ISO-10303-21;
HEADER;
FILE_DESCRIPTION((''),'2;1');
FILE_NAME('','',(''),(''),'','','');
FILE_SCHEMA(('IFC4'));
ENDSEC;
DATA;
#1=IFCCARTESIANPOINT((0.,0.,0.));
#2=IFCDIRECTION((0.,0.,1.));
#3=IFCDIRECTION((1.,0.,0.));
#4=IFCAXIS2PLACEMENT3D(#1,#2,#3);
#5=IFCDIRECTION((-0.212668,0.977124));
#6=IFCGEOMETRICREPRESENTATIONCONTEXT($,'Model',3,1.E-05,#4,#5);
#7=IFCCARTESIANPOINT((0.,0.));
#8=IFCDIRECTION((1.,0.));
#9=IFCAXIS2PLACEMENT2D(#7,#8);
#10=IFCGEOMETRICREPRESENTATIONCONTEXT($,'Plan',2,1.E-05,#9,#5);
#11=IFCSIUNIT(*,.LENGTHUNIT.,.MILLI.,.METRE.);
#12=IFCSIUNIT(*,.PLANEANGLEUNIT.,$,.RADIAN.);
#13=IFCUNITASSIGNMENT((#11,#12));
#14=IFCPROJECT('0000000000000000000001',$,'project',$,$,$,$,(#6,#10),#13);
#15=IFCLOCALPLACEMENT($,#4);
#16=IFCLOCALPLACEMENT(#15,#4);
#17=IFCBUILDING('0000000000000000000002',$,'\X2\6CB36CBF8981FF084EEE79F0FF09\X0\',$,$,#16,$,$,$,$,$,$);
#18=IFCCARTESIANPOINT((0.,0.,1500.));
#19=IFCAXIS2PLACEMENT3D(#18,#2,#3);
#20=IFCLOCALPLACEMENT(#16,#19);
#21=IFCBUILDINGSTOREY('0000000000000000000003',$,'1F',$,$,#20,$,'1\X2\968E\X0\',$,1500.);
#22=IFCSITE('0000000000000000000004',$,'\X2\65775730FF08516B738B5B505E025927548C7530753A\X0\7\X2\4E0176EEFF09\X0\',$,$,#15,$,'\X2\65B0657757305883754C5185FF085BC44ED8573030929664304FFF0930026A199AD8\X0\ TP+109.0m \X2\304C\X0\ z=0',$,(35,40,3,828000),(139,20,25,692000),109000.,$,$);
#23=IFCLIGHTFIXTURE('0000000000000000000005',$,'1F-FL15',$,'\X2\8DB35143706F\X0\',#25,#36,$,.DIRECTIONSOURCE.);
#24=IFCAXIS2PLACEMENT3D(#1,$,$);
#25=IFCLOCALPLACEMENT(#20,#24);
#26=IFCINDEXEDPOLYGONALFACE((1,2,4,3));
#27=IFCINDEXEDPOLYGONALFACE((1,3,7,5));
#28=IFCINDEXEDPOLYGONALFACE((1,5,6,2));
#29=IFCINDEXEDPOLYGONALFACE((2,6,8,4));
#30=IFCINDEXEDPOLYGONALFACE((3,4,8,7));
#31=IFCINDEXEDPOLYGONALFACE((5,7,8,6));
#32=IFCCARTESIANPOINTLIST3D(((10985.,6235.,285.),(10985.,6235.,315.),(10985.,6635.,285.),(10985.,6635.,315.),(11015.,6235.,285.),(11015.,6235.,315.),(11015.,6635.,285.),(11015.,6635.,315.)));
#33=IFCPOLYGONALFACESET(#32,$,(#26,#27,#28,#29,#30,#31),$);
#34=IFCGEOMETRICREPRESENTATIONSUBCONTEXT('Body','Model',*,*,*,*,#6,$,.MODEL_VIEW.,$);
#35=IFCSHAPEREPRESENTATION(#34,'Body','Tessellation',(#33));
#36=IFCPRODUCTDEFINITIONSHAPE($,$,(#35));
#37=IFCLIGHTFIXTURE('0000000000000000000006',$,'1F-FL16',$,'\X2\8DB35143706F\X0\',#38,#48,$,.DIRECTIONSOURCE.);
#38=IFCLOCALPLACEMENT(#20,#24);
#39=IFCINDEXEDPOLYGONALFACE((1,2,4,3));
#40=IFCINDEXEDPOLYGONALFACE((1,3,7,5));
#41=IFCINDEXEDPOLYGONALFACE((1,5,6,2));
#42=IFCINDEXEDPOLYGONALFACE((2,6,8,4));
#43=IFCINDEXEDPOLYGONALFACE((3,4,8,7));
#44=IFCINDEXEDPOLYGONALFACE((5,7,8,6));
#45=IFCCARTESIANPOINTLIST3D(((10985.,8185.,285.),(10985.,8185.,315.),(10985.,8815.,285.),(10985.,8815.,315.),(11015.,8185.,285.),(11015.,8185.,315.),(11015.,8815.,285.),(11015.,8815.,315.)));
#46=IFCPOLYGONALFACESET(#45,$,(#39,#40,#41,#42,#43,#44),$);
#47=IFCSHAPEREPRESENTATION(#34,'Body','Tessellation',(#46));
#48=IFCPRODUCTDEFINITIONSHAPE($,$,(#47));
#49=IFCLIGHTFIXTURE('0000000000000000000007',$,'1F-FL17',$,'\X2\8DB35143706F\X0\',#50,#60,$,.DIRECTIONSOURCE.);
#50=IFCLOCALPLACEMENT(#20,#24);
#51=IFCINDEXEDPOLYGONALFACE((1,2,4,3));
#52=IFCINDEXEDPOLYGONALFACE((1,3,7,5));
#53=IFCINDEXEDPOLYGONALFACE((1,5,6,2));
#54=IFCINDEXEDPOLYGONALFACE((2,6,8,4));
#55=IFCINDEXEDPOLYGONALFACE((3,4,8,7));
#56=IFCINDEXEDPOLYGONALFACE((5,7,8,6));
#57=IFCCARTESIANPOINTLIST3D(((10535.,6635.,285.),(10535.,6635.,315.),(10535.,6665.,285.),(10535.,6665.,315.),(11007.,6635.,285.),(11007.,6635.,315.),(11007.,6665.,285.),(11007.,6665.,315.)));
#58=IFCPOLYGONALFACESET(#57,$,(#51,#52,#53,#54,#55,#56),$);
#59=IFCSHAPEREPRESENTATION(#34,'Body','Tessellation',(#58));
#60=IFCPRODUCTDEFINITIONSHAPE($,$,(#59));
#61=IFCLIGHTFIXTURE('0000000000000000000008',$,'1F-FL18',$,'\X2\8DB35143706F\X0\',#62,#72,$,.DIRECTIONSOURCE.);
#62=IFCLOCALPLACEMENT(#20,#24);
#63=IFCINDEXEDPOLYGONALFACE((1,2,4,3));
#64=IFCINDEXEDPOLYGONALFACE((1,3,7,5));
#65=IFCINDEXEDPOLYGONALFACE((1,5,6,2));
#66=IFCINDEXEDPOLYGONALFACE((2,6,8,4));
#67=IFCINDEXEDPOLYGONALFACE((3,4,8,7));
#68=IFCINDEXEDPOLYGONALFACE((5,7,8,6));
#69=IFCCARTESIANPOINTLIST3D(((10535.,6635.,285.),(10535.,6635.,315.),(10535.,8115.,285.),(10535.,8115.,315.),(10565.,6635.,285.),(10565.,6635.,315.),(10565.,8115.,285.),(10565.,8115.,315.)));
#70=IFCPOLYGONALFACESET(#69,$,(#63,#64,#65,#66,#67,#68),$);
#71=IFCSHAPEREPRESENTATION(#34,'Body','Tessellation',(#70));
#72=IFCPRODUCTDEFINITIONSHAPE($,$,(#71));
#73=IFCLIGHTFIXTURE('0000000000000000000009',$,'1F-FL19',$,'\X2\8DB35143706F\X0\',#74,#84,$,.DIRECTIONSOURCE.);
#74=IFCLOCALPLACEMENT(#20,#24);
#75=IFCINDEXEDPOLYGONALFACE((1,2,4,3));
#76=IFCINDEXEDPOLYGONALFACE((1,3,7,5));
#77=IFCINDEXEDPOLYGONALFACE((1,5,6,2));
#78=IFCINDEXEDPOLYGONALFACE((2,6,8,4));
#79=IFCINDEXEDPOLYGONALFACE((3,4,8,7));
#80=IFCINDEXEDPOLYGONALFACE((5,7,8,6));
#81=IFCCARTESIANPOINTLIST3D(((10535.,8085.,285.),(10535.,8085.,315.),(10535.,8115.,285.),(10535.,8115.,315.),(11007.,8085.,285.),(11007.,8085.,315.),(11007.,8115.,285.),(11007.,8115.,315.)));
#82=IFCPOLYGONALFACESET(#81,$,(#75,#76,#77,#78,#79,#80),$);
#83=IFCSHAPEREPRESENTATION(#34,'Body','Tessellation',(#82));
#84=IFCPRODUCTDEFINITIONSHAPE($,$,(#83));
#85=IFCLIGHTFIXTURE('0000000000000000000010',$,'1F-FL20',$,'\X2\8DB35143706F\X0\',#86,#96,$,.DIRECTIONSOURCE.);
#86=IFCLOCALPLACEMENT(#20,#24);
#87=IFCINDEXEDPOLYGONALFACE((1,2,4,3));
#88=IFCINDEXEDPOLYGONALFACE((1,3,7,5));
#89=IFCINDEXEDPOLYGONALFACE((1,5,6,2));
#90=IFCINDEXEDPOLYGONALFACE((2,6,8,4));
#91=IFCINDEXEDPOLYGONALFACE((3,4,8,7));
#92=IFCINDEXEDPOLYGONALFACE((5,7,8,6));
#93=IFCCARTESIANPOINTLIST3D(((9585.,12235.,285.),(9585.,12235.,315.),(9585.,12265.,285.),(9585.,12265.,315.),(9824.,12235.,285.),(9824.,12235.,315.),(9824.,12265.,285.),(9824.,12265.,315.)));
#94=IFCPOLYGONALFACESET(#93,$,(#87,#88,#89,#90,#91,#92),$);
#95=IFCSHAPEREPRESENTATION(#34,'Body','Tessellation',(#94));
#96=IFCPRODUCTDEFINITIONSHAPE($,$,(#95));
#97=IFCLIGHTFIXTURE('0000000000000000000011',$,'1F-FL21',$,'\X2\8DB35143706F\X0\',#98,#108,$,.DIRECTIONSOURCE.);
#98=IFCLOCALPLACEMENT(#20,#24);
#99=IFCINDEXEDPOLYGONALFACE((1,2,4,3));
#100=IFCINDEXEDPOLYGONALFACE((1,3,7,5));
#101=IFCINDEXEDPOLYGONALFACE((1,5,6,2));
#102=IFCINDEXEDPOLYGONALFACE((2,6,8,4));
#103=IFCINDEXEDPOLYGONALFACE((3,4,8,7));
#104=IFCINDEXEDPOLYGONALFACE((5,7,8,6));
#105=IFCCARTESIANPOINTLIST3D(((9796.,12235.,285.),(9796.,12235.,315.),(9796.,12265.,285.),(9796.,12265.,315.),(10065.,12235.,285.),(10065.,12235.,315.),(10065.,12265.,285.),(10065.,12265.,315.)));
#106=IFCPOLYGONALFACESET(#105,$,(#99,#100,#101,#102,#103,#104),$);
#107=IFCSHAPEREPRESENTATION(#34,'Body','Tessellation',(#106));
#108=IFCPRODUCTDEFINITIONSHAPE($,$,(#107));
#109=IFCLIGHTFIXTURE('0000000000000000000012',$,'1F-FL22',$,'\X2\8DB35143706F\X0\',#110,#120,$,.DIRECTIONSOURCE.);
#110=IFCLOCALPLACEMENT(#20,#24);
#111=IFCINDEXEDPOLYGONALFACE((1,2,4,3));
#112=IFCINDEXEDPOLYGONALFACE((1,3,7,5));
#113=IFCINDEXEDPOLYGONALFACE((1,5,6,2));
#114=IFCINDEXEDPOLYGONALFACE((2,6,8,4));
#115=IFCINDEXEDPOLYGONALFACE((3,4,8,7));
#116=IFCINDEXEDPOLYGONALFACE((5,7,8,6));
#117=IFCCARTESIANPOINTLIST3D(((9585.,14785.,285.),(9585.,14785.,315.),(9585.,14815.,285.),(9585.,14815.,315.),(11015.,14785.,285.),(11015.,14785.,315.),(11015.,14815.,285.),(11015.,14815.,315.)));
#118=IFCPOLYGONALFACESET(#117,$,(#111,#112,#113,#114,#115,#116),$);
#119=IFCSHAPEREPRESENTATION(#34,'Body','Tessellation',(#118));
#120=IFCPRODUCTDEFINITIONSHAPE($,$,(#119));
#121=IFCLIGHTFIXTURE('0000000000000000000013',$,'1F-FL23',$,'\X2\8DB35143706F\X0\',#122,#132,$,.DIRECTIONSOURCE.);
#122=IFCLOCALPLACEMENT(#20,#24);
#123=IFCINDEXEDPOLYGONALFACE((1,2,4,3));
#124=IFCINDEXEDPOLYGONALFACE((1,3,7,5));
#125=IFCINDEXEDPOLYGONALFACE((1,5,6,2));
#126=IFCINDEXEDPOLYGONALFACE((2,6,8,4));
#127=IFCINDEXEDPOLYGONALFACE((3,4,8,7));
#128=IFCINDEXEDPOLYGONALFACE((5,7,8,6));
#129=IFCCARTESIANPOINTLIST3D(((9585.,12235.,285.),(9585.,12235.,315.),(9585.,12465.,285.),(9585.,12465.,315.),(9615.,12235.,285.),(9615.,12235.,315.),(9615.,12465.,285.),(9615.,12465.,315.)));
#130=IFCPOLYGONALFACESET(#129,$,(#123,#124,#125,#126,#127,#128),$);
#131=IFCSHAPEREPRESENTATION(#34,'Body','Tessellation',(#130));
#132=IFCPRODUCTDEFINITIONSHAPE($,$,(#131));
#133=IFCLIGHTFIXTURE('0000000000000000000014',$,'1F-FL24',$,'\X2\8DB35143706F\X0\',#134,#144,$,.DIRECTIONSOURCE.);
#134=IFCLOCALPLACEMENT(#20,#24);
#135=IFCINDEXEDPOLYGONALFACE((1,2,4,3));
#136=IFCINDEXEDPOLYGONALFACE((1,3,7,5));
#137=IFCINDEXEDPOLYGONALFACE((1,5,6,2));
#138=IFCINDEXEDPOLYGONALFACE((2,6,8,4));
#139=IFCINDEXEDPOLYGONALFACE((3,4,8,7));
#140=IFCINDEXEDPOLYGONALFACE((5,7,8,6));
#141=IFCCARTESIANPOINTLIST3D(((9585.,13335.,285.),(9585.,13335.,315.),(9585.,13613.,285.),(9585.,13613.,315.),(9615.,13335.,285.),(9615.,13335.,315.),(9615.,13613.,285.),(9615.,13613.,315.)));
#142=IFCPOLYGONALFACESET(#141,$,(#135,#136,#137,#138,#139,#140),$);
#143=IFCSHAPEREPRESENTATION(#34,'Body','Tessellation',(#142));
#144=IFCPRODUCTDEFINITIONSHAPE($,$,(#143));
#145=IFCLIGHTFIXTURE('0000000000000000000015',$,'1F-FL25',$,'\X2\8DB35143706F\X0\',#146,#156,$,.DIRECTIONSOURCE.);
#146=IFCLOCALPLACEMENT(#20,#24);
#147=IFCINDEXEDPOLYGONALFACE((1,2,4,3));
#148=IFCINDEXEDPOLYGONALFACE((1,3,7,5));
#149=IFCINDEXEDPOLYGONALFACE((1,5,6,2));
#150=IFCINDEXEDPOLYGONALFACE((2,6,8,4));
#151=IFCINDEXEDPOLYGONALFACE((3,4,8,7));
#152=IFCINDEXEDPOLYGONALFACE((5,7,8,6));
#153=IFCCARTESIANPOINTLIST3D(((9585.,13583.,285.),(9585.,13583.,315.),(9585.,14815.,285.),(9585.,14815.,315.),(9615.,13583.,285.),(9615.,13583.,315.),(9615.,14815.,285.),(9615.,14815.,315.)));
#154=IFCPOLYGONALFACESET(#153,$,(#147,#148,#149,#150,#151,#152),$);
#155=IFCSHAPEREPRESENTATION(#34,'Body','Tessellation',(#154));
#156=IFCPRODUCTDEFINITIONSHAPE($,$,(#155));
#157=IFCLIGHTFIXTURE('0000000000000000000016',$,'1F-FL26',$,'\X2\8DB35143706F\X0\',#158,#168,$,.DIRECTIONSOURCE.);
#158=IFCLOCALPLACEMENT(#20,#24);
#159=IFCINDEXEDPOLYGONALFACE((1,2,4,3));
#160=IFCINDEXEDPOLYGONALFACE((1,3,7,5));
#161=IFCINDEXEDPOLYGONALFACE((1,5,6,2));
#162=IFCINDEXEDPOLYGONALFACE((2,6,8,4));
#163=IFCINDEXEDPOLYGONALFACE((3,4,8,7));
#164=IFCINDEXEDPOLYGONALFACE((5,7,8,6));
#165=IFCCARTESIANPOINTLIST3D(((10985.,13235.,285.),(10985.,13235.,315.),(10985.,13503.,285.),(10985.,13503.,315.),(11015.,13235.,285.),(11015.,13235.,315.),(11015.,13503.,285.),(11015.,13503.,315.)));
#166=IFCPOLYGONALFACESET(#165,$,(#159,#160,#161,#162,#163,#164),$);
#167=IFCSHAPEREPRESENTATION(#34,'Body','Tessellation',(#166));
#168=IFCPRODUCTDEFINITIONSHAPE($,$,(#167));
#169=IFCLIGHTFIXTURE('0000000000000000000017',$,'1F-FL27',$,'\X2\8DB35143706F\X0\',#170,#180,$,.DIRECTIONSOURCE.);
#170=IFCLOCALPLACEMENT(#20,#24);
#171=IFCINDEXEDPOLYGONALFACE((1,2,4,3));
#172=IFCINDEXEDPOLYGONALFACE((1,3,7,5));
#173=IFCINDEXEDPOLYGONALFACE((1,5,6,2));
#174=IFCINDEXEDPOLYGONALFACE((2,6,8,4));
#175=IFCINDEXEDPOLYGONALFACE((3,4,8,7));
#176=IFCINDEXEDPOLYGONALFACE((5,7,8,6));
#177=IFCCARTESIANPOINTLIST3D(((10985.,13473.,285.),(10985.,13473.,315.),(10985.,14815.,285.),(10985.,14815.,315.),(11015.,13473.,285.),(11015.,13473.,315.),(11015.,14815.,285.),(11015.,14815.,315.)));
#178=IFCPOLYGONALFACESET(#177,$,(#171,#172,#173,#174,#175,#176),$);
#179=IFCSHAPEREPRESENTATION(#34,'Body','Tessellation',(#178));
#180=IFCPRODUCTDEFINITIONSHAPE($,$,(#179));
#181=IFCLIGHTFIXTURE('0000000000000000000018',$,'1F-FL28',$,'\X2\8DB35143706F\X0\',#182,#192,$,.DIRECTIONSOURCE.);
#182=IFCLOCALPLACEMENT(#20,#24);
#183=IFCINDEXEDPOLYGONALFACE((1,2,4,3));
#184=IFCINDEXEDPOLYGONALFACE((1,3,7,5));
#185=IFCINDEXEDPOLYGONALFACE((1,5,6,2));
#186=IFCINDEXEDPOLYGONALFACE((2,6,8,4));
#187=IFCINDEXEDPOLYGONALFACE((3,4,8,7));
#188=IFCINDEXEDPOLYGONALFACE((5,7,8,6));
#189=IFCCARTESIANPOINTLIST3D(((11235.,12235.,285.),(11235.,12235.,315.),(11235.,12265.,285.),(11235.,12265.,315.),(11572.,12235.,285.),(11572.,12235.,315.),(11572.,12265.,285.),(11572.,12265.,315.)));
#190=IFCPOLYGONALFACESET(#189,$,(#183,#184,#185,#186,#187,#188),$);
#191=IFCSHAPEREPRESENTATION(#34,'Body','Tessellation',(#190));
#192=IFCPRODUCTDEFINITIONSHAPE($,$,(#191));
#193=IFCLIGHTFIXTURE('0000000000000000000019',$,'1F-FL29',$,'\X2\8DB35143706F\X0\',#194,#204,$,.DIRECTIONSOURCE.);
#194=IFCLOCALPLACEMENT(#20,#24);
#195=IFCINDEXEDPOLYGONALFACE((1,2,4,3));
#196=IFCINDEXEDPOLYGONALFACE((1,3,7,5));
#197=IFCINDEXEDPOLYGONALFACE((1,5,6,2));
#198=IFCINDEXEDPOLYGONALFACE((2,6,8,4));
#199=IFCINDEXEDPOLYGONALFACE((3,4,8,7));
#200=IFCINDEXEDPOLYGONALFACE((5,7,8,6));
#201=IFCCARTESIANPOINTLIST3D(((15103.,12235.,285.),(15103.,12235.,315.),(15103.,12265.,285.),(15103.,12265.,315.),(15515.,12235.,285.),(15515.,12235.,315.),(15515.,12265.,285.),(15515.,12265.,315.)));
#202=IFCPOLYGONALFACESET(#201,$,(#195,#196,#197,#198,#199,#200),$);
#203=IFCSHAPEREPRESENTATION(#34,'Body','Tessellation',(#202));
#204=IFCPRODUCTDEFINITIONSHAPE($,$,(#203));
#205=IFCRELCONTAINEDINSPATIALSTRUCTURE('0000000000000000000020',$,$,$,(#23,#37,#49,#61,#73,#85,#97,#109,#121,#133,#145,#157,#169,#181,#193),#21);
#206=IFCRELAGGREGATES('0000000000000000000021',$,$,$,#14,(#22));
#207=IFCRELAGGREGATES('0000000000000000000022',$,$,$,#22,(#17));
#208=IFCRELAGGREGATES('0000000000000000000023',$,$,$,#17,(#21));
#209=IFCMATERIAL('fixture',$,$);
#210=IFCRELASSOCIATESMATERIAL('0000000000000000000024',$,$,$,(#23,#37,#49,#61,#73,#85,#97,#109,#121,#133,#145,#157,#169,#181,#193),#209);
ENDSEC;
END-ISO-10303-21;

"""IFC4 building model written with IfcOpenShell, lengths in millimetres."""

from ifc_helpers import new_model, si_unit, direction, frame, frame_2d, origin_with_axes, origin_2d_with_axis, place, context, subcontext, project, spatial, rectangle, extrude, material, element, save


model = new_model("IFC4")

# Units and contexts
model_context = context("Model", 3, precision=1e-05, world=origin_with_axes(), true_north=direction((-0.212668, 0.977124)))
plan_context = context("Plan", 2, precision=1e-05, world=origin_2d_with_axis(), true_north=direction((-0.212668, 0.977124)))
body_context = subcontext(model_context, "Body", "Model", "MODEL_VIEW")
ifc_project = project(units=[si_unit("LENGTHUNIT", "METRE", prefix="MILLI"), si_unit("PLANEANGLEUNIT", "RADIAN")], contexts=[model_context, plan_context])

# Site, building, storey
site_placement = place(None, origin_with_axes())
site = spatial("IfcSite", under=ifc_project, at=site_placement, Name="敷地（八王子市大和田町7丁目）", LongName="新敷地境界内（寄付地を除く）。標高 TP+109.0m が z=0", RefLatitude=(35, 40, 3, 828000), RefLongitude=(139, 20, 25, 692000), RefElevation=109000.0)
building_placement = place(site_placement, origin_with_axes())
building = spatial("IfcBuilding", under=site, at=building_placement, Name="河沿要（仮称）")
storey_placement = place(building_placement, frame((0.0, 0.0, 1500.0), z_axis=(0.0, 0.0, 1.0), x_axis=(1.0, 0.0, 0.0)))
storey = spatial("IfcBuildingStorey", under=building, at=storey_placement, Name="1F", LongName="1階", Elevation=1500.0)

# Light fixtures
ifc_material = material(Name="fixture")
light_fixture_1_placement = place(storey_placement, origin_with_axes())
element("IfcLightFixture", 1, at=light_fixture_1_placement, inside=storey, material=ifc_material, Name="1F-FL15", ObjectType="足元灯", PredefinedType="DIRECTIONSOURCE", context=body_context, shape_type="SweptSolid", body=[
    extrude(rectangle(XDim=30.0, YDim=400.0, at=frame_2d((11000.0, 6435.0))), frame((0.0, 0.0, 285.0)), (0.0, 0.0, 1.0), 30.0),
])
light_fixture_2_placement = place(storey_placement, origin_with_axes())
element("IfcLightFixture", 2, at=light_fixture_2_placement, inside=storey, material=ifc_material, Name="1F-FL16", ObjectType="足元灯", PredefinedType="DIRECTIONSOURCE", context=body_context, shape_type="SweptSolid", body=[
    extrude(rectangle(XDim=30.0, YDim=630.0, at=frame_2d((11000.0, 8500.0))), frame((0.0, 0.0, 285.0)), (0.0, 0.0, 1.0), 30.0),
])
light_fixture_3_placement = place(storey_placement, origin_with_axes())
element("IfcLightFixture", 3, at=light_fixture_3_placement, inside=storey, material=ifc_material, Name="1F-FL17", ObjectType="足元灯", PredefinedType="DIRECTIONSOURCE", context=body_context, shape_type="SweptSolid", body=[
    extrude(rectangle(XDim=472.0, YDim=30.0, at=frame_2d((10771.0, 6650.0))), frame((0.0, 0.0, 285.0)), (0.0, 0.0, 1.0), 30.0),
])
light_fixture_4_placement = place(storey_placement, origin_with_axes())
element("IfcLightFixture", 4, at=light_fixture_4_placement, inside=storey, material=ifc_material, Name="1F-FL18", ObjectType="足元灯", PredefinedType="DIRECTIONSOURCE", context=body_context, shape_type="SweptSolid", body=[
    extrude(rectangle(XDim=30.0, YDim=1480.0, at=frame_2d((10550.0, 7375.0))), frame((0.0, 0.0, 285.0)), (0.0, 0.0, 1.0), 30.0),
])
light_fixture_5_placement = place(storey_placement, origin_with_axes())
element("IfcLightFixture", 5, at=light_fixture_5_placement, inside=storey, material=ifc_material, Name="1F-FL19", ObjectType="足元灯", PredefinedType="DIRECTIONSOURCE", context=body_context, shape_type="SweptSolid", body=[
    extrude(rectangle(XDim=472.0, YDim=30.0, at=frame_2d((10771.0, 8100.0))), frame((0.0, 0.0, 285.0)), (0.0, 0.0, 1.0), 30.0),
])
light_fixture_6_placement = place(storey_placement, origin_with_axes())
element("IfcLightFixture", 6, at=light_fixture_6_placement, inside=storey, material=ifc_material, Name="1F-FL20", ObjectType="足元灯", PredefinedType="DIRECTIONSOURCE", context=body_context, shape_type="SweptSolid", body=[
    extrude(rectangle(XDim=239.0, YDim=30.0, at=frame_2d((9704.5, 12250.0))), frame((0.0, 0.0, 285.0)), (0.0, 0.0, 1.0), 30.0),
])
light_fixture_7_placement = place(storey_placement, origin_with_axes())
element("IfcLightFixture", 7, at=light_fixture_7_placement, inside=storey, material=ifc_material, Name="1F-FL21", ObjectType="足元灯", PredefinedType="DIRECTIONSOURCE", context=body_context, shape_type="SweptSolid", body=[
    extrude(rectangle(XDim=269.0, YDim=30.0, at=frame_2d((9930.5, 12250.0))), frame((0.0, 0.0, 285.0)), (0.0, 0.0, 1.0), 30.0),
])
light_fixture_8_placement = place(storey_placement, origin_with_axes())
element("IfcLightFixture", 8, at=light_fixture_8_placement, inside=storey, material=ifc_material, Name="1F-FL22", ObjectType="足元灯", PredefinedType="DIRECTIONSOURCE", context=body_context, shape_type="SweptSolid", body=[
    extrude(rectangle(XDim=1430.0, YDim=30.0, at=frame_2d((10300.0, 14800.0))), frame((0.0, 0.0, 285.0)), (0.0, 0.0, 1.0), 30.0),
])
light_fixture_9_placement = place(storey_placement, origin_with_axes())
element("IfcLightFixture", 9, at=light_fixture_9_placement, inside=storey, material=ifc_material, Name="1F-FL23", ObjectType="足元灯", PredefinedType="DIRECTIONSOURCE", context=body_context, shape_type="SweptSolid", body=[
    extrude(rectangle(XDim=30.0, YDim=230.0, at=frame_2d((9600.0, 12350.0))), frame((0.0, 0.0, 285.0)), (0.0, 0.0, 1.0), 30.0),
])
light_fixture_10_placement = place(storey_placement, origin_with_axes())
element("IfcLightFixture", 10, at=light_fixture_10_placement, inside=storey, material=ifc_material, Name="1F-FL24", ObjectType="足元灯", PredefinedType="DIRECTIONSOURCE", context=body_context, shape_type="SweptSolid", body=[
    extrude(rectangle(XDim=30.0, YDim=278.0, at=frame_2d((9600.0, 13474.0))), frame((0.0, 0.0, 285.0)), (0.0, 0.0, 1.0), 30.0),
])
light_fixture_11_placement = place(storey_placement, origin_with_axes())
element("IfcLightFixture", 11, at=light_fixture_11_placement, inside=storey, material=ifc_material, Name="1F-FL25", ObjectType="足元灯", PredefinedType="DIRECTIONSOURCE", context=body_context, shape_type="SweptSolid", body=[
    extrude(rectangle(XDim=30.0, YDim=1232.0, at=frame_2d((9600.0, 14199.0))), frame((0.0, 0.0, 285.0)), (0.0, 0.0, 1.0), 30.0),
])
light_fixture_12_placement = place(storey_placement, origin_with_axes())
element("IfcLightFixture", 12, at=light_fixture_12_placement, inside=storey, material=ifc_material, Name="1F-FL26", ObjectType="足元灯", PredefinedType="DIRECTIONSOURCE", context=body_context, shape_type="SweptSolid", body=[
    extrude(rectangle(XDim=30.0, YDim=268.0, at=frame_2d((11000.0, 13369.0))), frame((0.0, 0.0, 285.0)), (0.0, 0.0, 1.0), 30.0),
])
light_fixture_13_placement = place(storey_placement, origin_with_axes())
element("IfcLightFixture", 13, at=light_fixture_13_placement, inside=storey, material=ifc_material, Name="1F-FL27", ObjectType="足元灯", PredefinedType="DIRECTIONSOURCE", context=body_context, shape_type="SweptSolid", body=[
    extrude(rectangle(XDim=30.0, YDim=1342.0, at=frame_2d((11000.0, 14144.0))), frame((0.0, 0.0, 285.0)), (0.0, 0.0, 1.0), 30.0),
])
light_fixture_14_placement = place(storey_placement, origin_with_axes())
element("IfcLightFixture", 14, at=light_fixture_14_placement, inside=storey, material=ifc_material, Name="1F-FL28", ObjectType="足元灯", PredefinedType="DIRECTIONSOURCE", context=body_context, shape_type="SweptSolid", body=[
    extrude(rectangle(XDim=337.0, YDim=30.0, at=frame_2d((11403.5, 12250.0))), frame((0.0, 0.0, 285.0)), (0.0, 0.0, 1.0), 30.0),
])
light_fixture_15_placement = place(storey_placement, origin_with_axes())
element("IfcLightFixture", 15, at=light_fixture_15_placement, inside=storey, material=ifc_material, Name="1F-FL29", ObjectType="足元灯", PredefinedType="DIRECTIONSOURCE", context=body_context, shape_type="SweptSolid", body=[
    extrude(rectangle(XDim=412.0, YDim=30.0, at=frame_2d((15309.0, 12250.0))), frame((0.0, 0.0, 285.0)), (0.0, 0.0, 1.0), 30.0),
])

save(model, "model.ifc")
